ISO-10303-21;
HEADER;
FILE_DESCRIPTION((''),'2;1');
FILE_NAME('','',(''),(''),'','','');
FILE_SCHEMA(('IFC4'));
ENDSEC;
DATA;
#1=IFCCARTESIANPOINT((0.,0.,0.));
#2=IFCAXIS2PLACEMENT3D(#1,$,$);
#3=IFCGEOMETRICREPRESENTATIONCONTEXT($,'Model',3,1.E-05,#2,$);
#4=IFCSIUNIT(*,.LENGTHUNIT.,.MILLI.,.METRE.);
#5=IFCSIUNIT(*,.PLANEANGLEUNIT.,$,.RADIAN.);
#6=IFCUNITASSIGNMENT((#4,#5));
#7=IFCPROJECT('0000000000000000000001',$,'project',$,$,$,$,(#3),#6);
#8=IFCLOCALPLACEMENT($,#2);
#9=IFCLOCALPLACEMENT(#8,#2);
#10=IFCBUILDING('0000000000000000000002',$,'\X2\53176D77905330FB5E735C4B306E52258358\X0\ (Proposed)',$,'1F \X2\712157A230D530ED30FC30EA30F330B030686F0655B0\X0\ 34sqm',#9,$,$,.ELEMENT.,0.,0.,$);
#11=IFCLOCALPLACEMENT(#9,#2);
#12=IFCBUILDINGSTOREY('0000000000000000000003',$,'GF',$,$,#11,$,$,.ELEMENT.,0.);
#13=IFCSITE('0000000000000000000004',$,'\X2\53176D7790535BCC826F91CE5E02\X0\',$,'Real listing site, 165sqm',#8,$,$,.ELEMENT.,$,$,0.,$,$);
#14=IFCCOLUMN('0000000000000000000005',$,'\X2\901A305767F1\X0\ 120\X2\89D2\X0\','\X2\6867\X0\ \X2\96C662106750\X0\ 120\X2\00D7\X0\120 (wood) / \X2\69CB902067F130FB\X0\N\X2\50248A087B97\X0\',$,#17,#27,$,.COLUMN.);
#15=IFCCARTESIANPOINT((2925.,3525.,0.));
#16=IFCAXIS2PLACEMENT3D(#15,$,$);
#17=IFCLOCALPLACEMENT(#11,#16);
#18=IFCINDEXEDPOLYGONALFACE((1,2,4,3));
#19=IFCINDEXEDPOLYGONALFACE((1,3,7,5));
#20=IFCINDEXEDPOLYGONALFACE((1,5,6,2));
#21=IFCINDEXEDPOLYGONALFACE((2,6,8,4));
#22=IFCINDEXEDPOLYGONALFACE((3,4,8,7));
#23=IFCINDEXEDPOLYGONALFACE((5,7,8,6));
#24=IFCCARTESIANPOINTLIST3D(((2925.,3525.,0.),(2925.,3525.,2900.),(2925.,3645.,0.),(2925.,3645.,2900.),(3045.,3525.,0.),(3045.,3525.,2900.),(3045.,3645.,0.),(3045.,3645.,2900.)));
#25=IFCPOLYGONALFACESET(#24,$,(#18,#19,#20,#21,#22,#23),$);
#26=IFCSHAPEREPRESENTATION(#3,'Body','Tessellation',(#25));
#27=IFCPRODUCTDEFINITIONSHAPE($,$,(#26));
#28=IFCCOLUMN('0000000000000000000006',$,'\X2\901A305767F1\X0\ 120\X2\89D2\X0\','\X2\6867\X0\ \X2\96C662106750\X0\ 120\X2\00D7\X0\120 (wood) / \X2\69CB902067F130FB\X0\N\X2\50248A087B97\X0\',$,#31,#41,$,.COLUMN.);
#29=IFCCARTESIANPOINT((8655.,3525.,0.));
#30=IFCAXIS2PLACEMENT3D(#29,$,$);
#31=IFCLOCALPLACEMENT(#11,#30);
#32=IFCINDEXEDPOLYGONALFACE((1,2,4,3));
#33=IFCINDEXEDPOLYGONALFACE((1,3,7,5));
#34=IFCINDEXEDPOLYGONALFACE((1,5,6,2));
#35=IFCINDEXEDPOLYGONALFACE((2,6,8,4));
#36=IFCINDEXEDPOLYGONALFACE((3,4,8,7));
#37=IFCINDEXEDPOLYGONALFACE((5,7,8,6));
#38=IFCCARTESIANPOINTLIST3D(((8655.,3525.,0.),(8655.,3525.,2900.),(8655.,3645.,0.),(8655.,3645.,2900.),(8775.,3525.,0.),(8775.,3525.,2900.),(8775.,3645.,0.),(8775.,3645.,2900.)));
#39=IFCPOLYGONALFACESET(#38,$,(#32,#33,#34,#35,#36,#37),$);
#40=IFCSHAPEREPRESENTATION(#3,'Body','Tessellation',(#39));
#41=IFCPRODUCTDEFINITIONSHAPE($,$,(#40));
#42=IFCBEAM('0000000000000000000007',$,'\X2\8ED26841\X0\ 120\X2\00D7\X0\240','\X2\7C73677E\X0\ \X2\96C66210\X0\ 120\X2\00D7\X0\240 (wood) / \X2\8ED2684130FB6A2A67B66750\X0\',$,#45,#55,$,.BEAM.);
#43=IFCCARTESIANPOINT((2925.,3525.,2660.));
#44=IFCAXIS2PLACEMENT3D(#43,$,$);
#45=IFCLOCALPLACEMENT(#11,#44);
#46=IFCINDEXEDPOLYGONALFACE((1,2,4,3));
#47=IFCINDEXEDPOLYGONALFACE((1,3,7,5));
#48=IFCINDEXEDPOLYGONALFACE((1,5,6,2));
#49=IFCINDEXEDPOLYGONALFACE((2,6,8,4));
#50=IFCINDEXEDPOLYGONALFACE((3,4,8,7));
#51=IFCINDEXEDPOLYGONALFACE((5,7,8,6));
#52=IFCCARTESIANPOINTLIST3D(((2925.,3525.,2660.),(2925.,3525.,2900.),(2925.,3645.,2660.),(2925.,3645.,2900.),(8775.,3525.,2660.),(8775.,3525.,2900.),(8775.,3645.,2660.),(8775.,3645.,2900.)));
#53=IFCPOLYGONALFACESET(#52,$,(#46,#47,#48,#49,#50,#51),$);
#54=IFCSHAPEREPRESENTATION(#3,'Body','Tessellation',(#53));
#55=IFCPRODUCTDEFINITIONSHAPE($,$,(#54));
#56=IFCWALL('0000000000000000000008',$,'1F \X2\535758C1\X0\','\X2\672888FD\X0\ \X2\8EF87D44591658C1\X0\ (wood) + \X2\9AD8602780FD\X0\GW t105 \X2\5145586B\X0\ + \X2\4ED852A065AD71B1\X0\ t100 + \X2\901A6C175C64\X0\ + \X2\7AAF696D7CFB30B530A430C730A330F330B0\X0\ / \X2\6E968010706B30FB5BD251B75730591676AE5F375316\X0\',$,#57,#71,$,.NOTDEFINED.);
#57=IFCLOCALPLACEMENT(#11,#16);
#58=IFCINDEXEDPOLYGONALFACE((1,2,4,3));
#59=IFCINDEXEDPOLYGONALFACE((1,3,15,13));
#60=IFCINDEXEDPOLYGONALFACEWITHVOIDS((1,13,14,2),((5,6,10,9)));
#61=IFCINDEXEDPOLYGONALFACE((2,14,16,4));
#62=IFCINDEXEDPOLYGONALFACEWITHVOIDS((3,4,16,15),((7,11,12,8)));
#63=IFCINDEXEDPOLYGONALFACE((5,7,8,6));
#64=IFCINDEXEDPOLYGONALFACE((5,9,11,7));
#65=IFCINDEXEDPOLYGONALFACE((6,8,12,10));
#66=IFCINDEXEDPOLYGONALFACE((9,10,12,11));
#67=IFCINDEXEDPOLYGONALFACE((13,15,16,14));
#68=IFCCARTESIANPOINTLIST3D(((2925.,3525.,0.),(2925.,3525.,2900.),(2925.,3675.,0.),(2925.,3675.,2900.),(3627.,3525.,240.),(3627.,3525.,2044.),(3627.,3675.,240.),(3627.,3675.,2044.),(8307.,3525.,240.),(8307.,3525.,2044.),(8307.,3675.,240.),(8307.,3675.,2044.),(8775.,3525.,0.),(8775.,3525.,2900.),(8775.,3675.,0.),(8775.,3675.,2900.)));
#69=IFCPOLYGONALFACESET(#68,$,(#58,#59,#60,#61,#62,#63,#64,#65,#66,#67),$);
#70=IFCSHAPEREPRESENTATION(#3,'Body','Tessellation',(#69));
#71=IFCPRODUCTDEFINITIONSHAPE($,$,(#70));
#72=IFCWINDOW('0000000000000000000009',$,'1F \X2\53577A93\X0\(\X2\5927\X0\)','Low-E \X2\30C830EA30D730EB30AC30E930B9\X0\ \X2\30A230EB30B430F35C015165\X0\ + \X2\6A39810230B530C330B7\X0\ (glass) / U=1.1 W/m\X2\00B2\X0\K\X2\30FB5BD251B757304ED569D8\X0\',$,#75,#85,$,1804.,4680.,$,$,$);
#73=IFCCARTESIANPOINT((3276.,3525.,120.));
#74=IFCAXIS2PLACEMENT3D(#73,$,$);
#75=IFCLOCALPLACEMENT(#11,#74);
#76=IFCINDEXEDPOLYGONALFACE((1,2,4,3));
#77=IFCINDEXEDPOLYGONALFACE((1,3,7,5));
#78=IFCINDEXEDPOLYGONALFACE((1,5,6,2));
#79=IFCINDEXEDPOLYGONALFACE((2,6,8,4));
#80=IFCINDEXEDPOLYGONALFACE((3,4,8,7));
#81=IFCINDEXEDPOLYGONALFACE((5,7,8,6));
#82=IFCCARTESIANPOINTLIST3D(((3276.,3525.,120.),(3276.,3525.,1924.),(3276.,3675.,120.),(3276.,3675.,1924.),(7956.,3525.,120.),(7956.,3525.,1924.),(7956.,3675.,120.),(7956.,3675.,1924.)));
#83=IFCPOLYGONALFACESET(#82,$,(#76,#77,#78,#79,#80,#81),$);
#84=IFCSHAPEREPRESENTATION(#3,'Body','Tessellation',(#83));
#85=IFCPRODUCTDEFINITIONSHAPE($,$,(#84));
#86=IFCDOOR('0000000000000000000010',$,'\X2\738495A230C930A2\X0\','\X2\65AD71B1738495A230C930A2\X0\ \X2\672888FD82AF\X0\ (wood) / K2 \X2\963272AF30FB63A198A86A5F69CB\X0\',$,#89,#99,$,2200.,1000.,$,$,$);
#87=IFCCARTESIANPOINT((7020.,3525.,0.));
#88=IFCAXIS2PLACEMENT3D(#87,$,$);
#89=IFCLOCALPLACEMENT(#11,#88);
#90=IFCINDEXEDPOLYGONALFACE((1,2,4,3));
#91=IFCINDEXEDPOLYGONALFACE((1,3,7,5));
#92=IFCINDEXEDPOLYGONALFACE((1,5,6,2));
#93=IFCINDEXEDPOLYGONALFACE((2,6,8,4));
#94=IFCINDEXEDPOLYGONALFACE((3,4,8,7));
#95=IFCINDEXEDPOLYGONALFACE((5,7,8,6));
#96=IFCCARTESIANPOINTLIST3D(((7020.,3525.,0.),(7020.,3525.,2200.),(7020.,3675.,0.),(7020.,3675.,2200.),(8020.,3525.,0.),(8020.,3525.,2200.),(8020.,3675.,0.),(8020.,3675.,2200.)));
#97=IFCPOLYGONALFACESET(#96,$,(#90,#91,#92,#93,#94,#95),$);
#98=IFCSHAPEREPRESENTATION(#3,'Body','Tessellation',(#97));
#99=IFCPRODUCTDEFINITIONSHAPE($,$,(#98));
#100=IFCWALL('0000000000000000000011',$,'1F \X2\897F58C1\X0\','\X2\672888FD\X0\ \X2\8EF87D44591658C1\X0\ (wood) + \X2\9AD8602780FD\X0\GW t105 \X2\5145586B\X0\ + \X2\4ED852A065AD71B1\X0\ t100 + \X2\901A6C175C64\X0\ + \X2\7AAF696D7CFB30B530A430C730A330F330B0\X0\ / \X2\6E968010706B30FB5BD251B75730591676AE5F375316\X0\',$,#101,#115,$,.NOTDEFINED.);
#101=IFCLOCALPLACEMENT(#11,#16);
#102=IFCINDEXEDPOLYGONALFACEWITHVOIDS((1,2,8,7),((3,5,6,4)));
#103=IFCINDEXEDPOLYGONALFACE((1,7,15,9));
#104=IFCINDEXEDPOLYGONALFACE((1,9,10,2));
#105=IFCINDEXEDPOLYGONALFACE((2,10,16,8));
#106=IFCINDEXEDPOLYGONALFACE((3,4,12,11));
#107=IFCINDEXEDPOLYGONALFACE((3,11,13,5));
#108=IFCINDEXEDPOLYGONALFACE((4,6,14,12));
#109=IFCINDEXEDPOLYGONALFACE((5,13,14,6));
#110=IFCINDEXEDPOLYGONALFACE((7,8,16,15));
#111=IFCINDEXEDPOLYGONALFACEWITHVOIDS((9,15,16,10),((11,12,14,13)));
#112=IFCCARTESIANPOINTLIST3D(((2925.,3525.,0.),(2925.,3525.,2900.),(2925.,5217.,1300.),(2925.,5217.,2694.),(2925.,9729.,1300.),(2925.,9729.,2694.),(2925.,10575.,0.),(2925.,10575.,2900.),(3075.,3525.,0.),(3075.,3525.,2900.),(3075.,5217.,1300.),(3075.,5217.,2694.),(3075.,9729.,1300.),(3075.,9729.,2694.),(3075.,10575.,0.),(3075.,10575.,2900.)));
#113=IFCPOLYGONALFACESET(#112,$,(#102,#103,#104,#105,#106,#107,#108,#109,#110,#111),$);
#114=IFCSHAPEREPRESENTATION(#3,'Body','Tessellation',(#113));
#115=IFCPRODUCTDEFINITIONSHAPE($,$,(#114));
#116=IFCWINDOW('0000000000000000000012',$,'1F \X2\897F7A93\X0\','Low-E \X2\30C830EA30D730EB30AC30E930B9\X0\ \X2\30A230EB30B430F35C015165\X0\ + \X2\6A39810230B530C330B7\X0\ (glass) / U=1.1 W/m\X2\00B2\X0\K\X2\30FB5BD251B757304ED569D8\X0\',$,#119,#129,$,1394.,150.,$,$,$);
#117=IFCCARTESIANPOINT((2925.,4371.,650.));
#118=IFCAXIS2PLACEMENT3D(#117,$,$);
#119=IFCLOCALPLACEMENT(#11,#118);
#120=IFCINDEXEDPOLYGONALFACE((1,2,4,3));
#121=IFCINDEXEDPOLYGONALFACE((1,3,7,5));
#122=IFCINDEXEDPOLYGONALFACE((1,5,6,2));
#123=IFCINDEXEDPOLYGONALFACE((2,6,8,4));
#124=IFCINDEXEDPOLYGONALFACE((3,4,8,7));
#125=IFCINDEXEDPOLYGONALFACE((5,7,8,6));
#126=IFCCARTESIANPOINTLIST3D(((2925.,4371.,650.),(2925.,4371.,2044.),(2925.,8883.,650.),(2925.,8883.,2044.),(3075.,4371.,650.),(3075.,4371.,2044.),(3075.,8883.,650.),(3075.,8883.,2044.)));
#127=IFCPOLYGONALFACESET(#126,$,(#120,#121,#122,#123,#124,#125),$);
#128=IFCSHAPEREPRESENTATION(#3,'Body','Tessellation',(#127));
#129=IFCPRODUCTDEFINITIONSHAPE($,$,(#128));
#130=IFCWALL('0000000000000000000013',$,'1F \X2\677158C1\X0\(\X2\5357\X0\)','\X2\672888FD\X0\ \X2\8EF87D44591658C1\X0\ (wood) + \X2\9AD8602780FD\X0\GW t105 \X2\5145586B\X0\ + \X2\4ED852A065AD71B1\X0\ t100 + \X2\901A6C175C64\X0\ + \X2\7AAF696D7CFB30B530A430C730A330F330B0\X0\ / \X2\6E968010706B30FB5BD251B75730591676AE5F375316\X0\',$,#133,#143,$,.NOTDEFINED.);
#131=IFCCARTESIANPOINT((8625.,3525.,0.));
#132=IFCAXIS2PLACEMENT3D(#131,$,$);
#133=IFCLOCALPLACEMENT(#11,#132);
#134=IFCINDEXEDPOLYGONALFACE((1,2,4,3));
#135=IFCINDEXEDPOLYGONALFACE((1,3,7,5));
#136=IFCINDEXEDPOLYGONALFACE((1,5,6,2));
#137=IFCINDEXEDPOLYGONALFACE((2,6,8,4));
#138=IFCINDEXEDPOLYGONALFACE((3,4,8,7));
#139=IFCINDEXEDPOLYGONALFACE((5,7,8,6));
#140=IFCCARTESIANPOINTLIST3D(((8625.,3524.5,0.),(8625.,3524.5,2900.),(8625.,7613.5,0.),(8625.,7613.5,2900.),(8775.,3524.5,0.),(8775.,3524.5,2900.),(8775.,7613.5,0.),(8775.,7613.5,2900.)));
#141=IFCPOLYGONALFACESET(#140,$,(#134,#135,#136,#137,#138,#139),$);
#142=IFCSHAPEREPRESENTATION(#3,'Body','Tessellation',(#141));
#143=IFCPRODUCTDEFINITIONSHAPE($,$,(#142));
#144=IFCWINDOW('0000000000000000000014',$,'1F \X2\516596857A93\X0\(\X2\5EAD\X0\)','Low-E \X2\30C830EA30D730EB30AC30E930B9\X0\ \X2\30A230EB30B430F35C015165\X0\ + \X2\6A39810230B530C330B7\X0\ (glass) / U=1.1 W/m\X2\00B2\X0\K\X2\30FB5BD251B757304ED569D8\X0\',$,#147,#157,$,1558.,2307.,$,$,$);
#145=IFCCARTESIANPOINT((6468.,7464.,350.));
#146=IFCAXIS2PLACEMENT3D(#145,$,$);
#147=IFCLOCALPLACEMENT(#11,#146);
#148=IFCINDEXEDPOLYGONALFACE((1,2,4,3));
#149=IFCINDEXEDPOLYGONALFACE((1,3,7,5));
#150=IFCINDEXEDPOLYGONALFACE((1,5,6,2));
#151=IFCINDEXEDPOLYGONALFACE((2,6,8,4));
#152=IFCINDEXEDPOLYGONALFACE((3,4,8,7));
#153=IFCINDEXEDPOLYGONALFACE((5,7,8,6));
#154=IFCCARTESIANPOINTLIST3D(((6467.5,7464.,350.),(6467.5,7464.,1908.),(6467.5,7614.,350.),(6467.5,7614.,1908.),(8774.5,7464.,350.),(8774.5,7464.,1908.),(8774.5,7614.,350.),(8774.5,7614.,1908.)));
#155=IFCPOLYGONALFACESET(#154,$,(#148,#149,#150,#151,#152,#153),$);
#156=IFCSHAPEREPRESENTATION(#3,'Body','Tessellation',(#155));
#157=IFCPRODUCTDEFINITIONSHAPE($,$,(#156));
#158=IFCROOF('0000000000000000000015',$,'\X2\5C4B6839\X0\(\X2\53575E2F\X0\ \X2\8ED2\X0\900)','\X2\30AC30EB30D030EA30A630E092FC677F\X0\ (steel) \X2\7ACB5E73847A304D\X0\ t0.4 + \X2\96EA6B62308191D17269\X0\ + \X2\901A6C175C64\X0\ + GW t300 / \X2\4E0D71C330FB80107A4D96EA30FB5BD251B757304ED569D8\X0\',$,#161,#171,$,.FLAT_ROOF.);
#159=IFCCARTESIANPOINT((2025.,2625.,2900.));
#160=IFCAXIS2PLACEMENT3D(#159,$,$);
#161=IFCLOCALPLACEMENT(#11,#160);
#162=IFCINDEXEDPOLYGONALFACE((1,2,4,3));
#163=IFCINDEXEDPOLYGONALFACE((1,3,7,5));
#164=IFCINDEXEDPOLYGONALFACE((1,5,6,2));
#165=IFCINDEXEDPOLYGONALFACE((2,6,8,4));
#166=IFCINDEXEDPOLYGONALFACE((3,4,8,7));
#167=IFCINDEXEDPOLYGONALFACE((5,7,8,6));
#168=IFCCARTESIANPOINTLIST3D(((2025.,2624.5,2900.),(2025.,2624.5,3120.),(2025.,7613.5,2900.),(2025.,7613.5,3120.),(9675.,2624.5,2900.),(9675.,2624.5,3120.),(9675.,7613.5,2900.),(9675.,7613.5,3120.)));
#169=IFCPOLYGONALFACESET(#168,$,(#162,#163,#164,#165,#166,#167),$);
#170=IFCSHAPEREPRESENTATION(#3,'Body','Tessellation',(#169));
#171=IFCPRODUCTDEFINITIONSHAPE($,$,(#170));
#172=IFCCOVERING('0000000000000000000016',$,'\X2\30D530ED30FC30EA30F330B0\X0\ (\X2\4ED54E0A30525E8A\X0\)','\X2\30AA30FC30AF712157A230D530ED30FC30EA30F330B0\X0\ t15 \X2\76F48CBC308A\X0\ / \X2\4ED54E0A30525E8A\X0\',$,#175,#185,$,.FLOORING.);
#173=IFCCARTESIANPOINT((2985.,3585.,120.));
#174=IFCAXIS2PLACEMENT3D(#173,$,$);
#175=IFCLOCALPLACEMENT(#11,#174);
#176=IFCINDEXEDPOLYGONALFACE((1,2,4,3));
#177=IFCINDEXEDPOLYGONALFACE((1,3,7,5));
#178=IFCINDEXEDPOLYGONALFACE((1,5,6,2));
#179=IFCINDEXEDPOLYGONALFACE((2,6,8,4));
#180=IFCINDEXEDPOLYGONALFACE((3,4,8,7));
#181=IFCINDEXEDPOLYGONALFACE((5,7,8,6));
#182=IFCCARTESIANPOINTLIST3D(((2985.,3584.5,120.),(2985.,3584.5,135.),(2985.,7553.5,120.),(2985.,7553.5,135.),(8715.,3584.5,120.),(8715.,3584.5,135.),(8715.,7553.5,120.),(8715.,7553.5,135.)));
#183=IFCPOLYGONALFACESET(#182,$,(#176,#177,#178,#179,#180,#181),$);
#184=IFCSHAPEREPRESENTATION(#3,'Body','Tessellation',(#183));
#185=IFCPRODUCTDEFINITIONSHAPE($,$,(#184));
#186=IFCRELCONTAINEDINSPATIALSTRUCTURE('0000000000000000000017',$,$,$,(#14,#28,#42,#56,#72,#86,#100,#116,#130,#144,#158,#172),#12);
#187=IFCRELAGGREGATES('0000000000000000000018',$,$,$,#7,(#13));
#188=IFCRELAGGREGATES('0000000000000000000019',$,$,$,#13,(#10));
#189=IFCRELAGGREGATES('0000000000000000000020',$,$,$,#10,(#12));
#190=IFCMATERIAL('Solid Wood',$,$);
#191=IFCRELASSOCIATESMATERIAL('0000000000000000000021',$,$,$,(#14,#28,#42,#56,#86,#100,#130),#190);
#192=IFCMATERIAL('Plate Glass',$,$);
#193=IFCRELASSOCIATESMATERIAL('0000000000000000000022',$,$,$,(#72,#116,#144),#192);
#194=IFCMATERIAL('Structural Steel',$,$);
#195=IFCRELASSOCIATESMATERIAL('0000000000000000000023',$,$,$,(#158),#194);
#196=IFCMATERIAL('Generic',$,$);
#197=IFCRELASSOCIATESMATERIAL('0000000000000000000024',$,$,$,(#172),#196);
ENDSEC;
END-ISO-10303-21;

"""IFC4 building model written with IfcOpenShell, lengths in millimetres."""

from ifc_helpers import new_model, si_unit, frame, frame_2d, origin, place, context, project, spatial, rectangle, extrude, material, element, fill, save


model = new_model("IFC4")

# Units and contexts
model_context = context("Model", 3, precision=1e-05, world=origin())
ifc_project = project(units=[si_unit("LENGTHUNIT", "METRE", prefix="MILLI"), si_unit("PLANEANGLEUNIT", "RADIAN")], contexts=[model_context])

# Site, building, storey
site_placement = place(None, origin())
site = spatial("IfcSite", under=ifc_project, at=site_placement, Name="北海道富良野市", ObjectType="Real listing site, 165sqm", CompositionType="ELEMENT", RefElevation=0.0)
building_placement = place(site_placement, origin())
building = spatial("IfcBuilding", under=site, at=building_placement, Name="北海道・平屋の別荘 (Proposed)", ObjectType="1F 無垢フローリングと漆喰 34sqm", CompositionType="ELEMENT", ElevationOfRefHeight=0.0, ElevationOfTerrain=0.0)
storey_placement = place(building_placement, origin())
storey = spatial("IfcBuildingStorey", under=building, at=storey_placement, Name="GF", CompositionType="ELEMENT", Elevation=0.0)

# Columns
ifc_material_1 = material(Name="Solid Wood")
column_1_placement = place(storey_placement, frame((2925.0, 3525.0, 0.0)))
element("IfcColumn", 1, at=column_1_placement, inside=storey, material=ifc_material_1, Name="通し柱 120角", Description="桧 集成材 120×120 (wood) / 構造柱・N値計算", PredefinedType="COLUMN", context=model_context, shape_type="SweptSolid", body=[
    extrude(rectangle(XDim=120.0, YDim=120.0, at=frame_2d((60.0, 60.0))), frame((2925.0, 3525.0, 0.0)), (0.0, 0.0, 1.0), 2900.0),
])
column_2_placement = place(storey_placement, frame((8655.0, 3525.0, 0.0)))
element("IfcColumn", 2, at=column_2_placement, inside=storey, material=ifc_material_1, Name="通し柱 120角", Description="桧 集成材 120×120 (wood) / 構造柱・N値計算", PredefinedType="COLUMN", context=model_context, shape_type="SweptSolid", body=[
    extrude(rectangle(XDim=120.0, YDim=120.0, at=frame_2d((60.0, 60.0))), frame((8655.0, 3525.0, 0.0)), (0.0, 0.0, 1.0), 2900.0),
])

# Beam
beam_1_placement = place(storey_placement, frame((2925.0, 3525.0, 2660.0)))
element("IfcBeam", 3, at=beam_1_placement, inside=storey, material=ifc_material_1, Name="軒桁 120×240", Description="米松 集成 120×240 (wood) / 軒桁・横架材", PredefinedType="BEAM", context=model_context, shape_type="SweptSolid", body=[
    extrude(rectangle(XDim=5850.0, YDim=120.0, at=frame_2d((2925.0, 60.0))), frame((2925.0, 3525.0, 2660.0)), (0.0, 0.0, 1.0), 240.0),
])

# Wall, openings, window, door
wall_1_placement = place(storey_placement, frame((2925.0, 3525.0, 0.0)))
wall_1 = element("IfcWall", 4, at=wall_1_placement, inside=storey, material=ifc_material_1, Name="1F 南壁", Description="木製 軸組外壁 (wood) + 高性能GW t105 充填 + 付加断熱 t100 + 通気層 + 窯業系サイディング / 準耐火・寒冷地外皮強化", PredefinedType="NOTDEFINED", context=model_context, shape_type="SweptSolid", body=[
    extrude(rectangle(XDim=5850.0, YDim=150.0, at=frame_2d((2925.0, 75.0))), frame((2925.0, 3525.0, 0.0)), (0.0, 0.0, 1.0), 2900.0),
])
opening_1_placement = place(storey_placement, frame((3276.0, 3525.0, 120.0)))
opening_1 = element("IfcOpeningElement", 5, at=opening_1_placement, cuts=wall_1, PredefinedType="NOTDEFINED", context=model_context, shape_type="SweptSolid", body=[
    extrude(rectangle(XDim=4680.0, YDim=150.0, at=frame_2d((2340.0, 75.0))), frame((3276.0, 3525.0, 120.0)), (0.0, 0.0, 1.0), 1804.0),
])
opening_2_placement = place(storey_placement, frame((7020.0, 3525.0, 0.0)))
opening_2 = element("IfcOpeningElement", 6, at=opening_2_placement, cuts=wall_1, PredefinedType="NOTDEFINED", context=model_context, shape_type="SweptSolid", body=[
    extrude(rectangle(XDim=1000.0, YDim=150.0, at=frame_2d((500.0, 75.0))), frame((7020.0, 3525.0, 0.0)), (0.0, 0.0, 1.0), 2200.0),
])
ifc_material_2 = material(Name="Plate Glass")
window_1_placement = place(storey_placement, frame((3276.0, 3525.0, 120.0)))
window_1 = element("IfcWindow", 7, at=window_1_placement, inside=storey, material=ifc_material_2, Name="1F 南窓(大)", Description="Low-E トリプルガラス アルゴン封入 + 樹脂サッシ (glass) / U=1.1 W/m²K・寒冷地仕様", OverallHeight=1804.0, OverallWidth=4680.0, context=model_context, shape_type="SweptSolid", body=[
    extrude(rectangle(XDim=4680.0, YDim=150.0, at=frame_2d((2340.0, 75.0))), frame((3276.0, 3525.0, 120.0)), (0.0, 0.0, 1.0), 1804.0),
])
fill(opening_1, window_1)
door_1_placement = place(storey_placement, frame((7020.0, 3525.0, 0.0)))
door_1 = element("IfcDoor", 8, at=door_1_placement, inside=storey, material=ifc_material_1, Name="玄関ドア", Description="断熱玄関ドア 木製芯 (wood) / K2 防犯・採風機構", OverallHeight=2200.0, OverallWidth=1000.0, context=model_context, shape_type="SweptSolid", body=[
    extrude(rectangle(XDim=1000.0, YDim=150.0, at=frame_2d((500.0, 75.0))), frame((7020.0, 3525.0, 0.0)), (0.0, 0.0, 1.0), 2200.0),
])
fill(opening_2, door_1)

# Walls, openings, windows
wall_2_placement = place(storey_placement, frame((2925.0, 3525.0, 0.0)))
wall_2 = element("IfcWall", 9, at=wall_2_placement, inside=storey, material=ifc_material_1, Name="1F 西壁", Description="木製 軸組外壁 (wood) + 高性能GW t105 充填 + 付加断熱 t100 + 通気層 + 窯業系サイディング / 準耐火・寒冷地外皮強化", PredefinedType="NOTDEFINED", context=model_context, shape_type="SweptSolid", body=[
    extrude(rectangle(XDim=150.0, YDim=7050.0, at=frame_2d((75.0, 3525.0))), frame((2925.0, 3525.0, 0.0)), (0.0, 0.0, 1.0), 2900.0),
])
opening_3_placement = place(storey_placement, frame((2925.0, 4371.0, 650.0)))
opening_3 = element("IfcOpeningElement", 10, at=opening_3_placement, cuts=wall_2, PredefinedType="NOTDEFINED", context=model_context, shape_type="SweptSolid", body=[
    extrude(rectangle(XDim=150.0, YDim=4512.0, at=frame_2d((75.0, 2256.0))), frame((2925.0, 4371.0, 650.0)), (0.0, 0.0, 1.0), 1394.0),
])
window_2_placement = place(storey_placement, frame((2925.0, 4371.0, 650.0)))
window_2 = element("IfcWindow", 11, at=window_2_placement, inside=storey, material=ifc_material_2, Name="1F 西窓", Description="Low-E トリプルガラス アルゴン封入 + 樹脂サッシ (glass) / U=1.1 W/m²K・寒冷地仕様", OverallHeight=1394.0, OverallWidth=150.0, context=model_context, shape_type="SweptSolid", body=[
    extrude(rectangle(XDim=150.0, YDim=4512.0, at=frame_2d((75.0, 2256.0))), frame((2925.0, 4371.0, 650.0)), (0.0, 0.0, 1.0), 1394.0),
])
fill(opening_3, window_2)
wall_3_placement = place(storey_placement, frame((8625.0, 3525.0, 0.0)))
wall_3 = element("IfcWall", 12, at=wall_3_placement, inside=storey, material=ifc_material_1, Name="1F 東壁(南)", Description="木製 軸組外壁 (wood) + 高性能GW t105 充填 + 付加断熱 t100 + 通気層 + 窯業系サイディング / 準耐火・寒冷地外皮強化", PredefinedType="NOTDEFINED", context=model_context, shape_type="SweptSolid", body=[
    extrude(rectangle(XDim=150.0, YDim=4089.0, at=frame_2d((75.0, 2044.0))), frame((8625.0, 3525.0, 0.0)), (0.0, 0.0, 1.0), 2900.0),
])
opening_4_placement = place(storey_placement, frame((6468.0, 7464.0, 350.0)))
opening_4 = element("IfcOpeningElement", 13, at=opening_4_placement, cuts=wall_3, PredefinedType="NOTDEFINED", context=model_context, shape_type="SweptSolid", body=[
    extrude(rectangle(XDim=2307.0, YDim=150.0, at=frame_2d((1153.0, 75.0))), frame((6468.0, 7464.0, 350.0)), (0.0, 0.0, 1.0), 1558.0),
])
window_3_placement = place(storey_placement, frame((6468.0, 7464.0, 350.0)))
window_3 = element("IfcWindow", 14, at=window_3_placement, inside=storey, material=ifc_material_2, Name="1F 入隅窓(庭)", Description="Low-E トリプルガラス アルゴン封入 + 樹脂サッシ (glass) / U=1.1 W/m²K・寒冷地仕様", OverallHeight=1558.0, OverallWidth=2307.0, context=model_context, shape_type="SweptSolid", body=[
    extrude(rectangle(XDim=2307.0, YDim=150.0, at=frame_2d((1153.0, 75.0))), frame((6468.0, 7464.0, 350.0)), (0.0, 0.0, 1.0), 1558.0),
])
fill(opening_4, window_3)

# Roof
ifc_material_3 = material(Name="Structural Steel")
roof_placement = place(storey_placement, frame((2025.0, 2625.0, 2900.0)))
element("IfcRoof", 15, at=roof_placement, inside=storey, material=ifc_material_3, Name="屋根(南帯 軒900)", Description="ガルバリウム鋼板 (steel) 立平葺き t0.4 + 雪止め金物 + 通気層 + GW t300 / 不燃・耐積雪・寒冷地仕様", PredefinedType="FLAT_ROOF", context=model_context, shape_type="SweptSolid", body=[
    extrude(rectangle(XDim=7650.0, YDim=4989.0, at=frame_2d((3825.0, 2494.0))), frame((2025.0, 2625.0, 2900.0)), (0.0, 0.0, 1.0), 220.0),
])

# Covering
ifc_material_4 = material(Name="Generic")
covering_1_placement = place(storey_placement, frame((2985.0, 3585.0, 120.0)))
element("IfcCovering", 16, at=covering_1_placement, inside=storey, material=ifc_material_4, Name="フローリング (仕上げ床)", Description="オーク無垢フローリング t15 直貼り / 仕上げ床", PredefinedType="FLOORING", context=model_context, shape_type="SweptSolid", body=[
    extrude(rectangle(XDim=5730.0, YDim=3969.0, at=frame_2d((2865.0, 1984.0))), frame((2985.0, 3585.0, 120.0)), (0.0, 0.0, 1.0), 15.0),
])

save(model, "model.ifc")
